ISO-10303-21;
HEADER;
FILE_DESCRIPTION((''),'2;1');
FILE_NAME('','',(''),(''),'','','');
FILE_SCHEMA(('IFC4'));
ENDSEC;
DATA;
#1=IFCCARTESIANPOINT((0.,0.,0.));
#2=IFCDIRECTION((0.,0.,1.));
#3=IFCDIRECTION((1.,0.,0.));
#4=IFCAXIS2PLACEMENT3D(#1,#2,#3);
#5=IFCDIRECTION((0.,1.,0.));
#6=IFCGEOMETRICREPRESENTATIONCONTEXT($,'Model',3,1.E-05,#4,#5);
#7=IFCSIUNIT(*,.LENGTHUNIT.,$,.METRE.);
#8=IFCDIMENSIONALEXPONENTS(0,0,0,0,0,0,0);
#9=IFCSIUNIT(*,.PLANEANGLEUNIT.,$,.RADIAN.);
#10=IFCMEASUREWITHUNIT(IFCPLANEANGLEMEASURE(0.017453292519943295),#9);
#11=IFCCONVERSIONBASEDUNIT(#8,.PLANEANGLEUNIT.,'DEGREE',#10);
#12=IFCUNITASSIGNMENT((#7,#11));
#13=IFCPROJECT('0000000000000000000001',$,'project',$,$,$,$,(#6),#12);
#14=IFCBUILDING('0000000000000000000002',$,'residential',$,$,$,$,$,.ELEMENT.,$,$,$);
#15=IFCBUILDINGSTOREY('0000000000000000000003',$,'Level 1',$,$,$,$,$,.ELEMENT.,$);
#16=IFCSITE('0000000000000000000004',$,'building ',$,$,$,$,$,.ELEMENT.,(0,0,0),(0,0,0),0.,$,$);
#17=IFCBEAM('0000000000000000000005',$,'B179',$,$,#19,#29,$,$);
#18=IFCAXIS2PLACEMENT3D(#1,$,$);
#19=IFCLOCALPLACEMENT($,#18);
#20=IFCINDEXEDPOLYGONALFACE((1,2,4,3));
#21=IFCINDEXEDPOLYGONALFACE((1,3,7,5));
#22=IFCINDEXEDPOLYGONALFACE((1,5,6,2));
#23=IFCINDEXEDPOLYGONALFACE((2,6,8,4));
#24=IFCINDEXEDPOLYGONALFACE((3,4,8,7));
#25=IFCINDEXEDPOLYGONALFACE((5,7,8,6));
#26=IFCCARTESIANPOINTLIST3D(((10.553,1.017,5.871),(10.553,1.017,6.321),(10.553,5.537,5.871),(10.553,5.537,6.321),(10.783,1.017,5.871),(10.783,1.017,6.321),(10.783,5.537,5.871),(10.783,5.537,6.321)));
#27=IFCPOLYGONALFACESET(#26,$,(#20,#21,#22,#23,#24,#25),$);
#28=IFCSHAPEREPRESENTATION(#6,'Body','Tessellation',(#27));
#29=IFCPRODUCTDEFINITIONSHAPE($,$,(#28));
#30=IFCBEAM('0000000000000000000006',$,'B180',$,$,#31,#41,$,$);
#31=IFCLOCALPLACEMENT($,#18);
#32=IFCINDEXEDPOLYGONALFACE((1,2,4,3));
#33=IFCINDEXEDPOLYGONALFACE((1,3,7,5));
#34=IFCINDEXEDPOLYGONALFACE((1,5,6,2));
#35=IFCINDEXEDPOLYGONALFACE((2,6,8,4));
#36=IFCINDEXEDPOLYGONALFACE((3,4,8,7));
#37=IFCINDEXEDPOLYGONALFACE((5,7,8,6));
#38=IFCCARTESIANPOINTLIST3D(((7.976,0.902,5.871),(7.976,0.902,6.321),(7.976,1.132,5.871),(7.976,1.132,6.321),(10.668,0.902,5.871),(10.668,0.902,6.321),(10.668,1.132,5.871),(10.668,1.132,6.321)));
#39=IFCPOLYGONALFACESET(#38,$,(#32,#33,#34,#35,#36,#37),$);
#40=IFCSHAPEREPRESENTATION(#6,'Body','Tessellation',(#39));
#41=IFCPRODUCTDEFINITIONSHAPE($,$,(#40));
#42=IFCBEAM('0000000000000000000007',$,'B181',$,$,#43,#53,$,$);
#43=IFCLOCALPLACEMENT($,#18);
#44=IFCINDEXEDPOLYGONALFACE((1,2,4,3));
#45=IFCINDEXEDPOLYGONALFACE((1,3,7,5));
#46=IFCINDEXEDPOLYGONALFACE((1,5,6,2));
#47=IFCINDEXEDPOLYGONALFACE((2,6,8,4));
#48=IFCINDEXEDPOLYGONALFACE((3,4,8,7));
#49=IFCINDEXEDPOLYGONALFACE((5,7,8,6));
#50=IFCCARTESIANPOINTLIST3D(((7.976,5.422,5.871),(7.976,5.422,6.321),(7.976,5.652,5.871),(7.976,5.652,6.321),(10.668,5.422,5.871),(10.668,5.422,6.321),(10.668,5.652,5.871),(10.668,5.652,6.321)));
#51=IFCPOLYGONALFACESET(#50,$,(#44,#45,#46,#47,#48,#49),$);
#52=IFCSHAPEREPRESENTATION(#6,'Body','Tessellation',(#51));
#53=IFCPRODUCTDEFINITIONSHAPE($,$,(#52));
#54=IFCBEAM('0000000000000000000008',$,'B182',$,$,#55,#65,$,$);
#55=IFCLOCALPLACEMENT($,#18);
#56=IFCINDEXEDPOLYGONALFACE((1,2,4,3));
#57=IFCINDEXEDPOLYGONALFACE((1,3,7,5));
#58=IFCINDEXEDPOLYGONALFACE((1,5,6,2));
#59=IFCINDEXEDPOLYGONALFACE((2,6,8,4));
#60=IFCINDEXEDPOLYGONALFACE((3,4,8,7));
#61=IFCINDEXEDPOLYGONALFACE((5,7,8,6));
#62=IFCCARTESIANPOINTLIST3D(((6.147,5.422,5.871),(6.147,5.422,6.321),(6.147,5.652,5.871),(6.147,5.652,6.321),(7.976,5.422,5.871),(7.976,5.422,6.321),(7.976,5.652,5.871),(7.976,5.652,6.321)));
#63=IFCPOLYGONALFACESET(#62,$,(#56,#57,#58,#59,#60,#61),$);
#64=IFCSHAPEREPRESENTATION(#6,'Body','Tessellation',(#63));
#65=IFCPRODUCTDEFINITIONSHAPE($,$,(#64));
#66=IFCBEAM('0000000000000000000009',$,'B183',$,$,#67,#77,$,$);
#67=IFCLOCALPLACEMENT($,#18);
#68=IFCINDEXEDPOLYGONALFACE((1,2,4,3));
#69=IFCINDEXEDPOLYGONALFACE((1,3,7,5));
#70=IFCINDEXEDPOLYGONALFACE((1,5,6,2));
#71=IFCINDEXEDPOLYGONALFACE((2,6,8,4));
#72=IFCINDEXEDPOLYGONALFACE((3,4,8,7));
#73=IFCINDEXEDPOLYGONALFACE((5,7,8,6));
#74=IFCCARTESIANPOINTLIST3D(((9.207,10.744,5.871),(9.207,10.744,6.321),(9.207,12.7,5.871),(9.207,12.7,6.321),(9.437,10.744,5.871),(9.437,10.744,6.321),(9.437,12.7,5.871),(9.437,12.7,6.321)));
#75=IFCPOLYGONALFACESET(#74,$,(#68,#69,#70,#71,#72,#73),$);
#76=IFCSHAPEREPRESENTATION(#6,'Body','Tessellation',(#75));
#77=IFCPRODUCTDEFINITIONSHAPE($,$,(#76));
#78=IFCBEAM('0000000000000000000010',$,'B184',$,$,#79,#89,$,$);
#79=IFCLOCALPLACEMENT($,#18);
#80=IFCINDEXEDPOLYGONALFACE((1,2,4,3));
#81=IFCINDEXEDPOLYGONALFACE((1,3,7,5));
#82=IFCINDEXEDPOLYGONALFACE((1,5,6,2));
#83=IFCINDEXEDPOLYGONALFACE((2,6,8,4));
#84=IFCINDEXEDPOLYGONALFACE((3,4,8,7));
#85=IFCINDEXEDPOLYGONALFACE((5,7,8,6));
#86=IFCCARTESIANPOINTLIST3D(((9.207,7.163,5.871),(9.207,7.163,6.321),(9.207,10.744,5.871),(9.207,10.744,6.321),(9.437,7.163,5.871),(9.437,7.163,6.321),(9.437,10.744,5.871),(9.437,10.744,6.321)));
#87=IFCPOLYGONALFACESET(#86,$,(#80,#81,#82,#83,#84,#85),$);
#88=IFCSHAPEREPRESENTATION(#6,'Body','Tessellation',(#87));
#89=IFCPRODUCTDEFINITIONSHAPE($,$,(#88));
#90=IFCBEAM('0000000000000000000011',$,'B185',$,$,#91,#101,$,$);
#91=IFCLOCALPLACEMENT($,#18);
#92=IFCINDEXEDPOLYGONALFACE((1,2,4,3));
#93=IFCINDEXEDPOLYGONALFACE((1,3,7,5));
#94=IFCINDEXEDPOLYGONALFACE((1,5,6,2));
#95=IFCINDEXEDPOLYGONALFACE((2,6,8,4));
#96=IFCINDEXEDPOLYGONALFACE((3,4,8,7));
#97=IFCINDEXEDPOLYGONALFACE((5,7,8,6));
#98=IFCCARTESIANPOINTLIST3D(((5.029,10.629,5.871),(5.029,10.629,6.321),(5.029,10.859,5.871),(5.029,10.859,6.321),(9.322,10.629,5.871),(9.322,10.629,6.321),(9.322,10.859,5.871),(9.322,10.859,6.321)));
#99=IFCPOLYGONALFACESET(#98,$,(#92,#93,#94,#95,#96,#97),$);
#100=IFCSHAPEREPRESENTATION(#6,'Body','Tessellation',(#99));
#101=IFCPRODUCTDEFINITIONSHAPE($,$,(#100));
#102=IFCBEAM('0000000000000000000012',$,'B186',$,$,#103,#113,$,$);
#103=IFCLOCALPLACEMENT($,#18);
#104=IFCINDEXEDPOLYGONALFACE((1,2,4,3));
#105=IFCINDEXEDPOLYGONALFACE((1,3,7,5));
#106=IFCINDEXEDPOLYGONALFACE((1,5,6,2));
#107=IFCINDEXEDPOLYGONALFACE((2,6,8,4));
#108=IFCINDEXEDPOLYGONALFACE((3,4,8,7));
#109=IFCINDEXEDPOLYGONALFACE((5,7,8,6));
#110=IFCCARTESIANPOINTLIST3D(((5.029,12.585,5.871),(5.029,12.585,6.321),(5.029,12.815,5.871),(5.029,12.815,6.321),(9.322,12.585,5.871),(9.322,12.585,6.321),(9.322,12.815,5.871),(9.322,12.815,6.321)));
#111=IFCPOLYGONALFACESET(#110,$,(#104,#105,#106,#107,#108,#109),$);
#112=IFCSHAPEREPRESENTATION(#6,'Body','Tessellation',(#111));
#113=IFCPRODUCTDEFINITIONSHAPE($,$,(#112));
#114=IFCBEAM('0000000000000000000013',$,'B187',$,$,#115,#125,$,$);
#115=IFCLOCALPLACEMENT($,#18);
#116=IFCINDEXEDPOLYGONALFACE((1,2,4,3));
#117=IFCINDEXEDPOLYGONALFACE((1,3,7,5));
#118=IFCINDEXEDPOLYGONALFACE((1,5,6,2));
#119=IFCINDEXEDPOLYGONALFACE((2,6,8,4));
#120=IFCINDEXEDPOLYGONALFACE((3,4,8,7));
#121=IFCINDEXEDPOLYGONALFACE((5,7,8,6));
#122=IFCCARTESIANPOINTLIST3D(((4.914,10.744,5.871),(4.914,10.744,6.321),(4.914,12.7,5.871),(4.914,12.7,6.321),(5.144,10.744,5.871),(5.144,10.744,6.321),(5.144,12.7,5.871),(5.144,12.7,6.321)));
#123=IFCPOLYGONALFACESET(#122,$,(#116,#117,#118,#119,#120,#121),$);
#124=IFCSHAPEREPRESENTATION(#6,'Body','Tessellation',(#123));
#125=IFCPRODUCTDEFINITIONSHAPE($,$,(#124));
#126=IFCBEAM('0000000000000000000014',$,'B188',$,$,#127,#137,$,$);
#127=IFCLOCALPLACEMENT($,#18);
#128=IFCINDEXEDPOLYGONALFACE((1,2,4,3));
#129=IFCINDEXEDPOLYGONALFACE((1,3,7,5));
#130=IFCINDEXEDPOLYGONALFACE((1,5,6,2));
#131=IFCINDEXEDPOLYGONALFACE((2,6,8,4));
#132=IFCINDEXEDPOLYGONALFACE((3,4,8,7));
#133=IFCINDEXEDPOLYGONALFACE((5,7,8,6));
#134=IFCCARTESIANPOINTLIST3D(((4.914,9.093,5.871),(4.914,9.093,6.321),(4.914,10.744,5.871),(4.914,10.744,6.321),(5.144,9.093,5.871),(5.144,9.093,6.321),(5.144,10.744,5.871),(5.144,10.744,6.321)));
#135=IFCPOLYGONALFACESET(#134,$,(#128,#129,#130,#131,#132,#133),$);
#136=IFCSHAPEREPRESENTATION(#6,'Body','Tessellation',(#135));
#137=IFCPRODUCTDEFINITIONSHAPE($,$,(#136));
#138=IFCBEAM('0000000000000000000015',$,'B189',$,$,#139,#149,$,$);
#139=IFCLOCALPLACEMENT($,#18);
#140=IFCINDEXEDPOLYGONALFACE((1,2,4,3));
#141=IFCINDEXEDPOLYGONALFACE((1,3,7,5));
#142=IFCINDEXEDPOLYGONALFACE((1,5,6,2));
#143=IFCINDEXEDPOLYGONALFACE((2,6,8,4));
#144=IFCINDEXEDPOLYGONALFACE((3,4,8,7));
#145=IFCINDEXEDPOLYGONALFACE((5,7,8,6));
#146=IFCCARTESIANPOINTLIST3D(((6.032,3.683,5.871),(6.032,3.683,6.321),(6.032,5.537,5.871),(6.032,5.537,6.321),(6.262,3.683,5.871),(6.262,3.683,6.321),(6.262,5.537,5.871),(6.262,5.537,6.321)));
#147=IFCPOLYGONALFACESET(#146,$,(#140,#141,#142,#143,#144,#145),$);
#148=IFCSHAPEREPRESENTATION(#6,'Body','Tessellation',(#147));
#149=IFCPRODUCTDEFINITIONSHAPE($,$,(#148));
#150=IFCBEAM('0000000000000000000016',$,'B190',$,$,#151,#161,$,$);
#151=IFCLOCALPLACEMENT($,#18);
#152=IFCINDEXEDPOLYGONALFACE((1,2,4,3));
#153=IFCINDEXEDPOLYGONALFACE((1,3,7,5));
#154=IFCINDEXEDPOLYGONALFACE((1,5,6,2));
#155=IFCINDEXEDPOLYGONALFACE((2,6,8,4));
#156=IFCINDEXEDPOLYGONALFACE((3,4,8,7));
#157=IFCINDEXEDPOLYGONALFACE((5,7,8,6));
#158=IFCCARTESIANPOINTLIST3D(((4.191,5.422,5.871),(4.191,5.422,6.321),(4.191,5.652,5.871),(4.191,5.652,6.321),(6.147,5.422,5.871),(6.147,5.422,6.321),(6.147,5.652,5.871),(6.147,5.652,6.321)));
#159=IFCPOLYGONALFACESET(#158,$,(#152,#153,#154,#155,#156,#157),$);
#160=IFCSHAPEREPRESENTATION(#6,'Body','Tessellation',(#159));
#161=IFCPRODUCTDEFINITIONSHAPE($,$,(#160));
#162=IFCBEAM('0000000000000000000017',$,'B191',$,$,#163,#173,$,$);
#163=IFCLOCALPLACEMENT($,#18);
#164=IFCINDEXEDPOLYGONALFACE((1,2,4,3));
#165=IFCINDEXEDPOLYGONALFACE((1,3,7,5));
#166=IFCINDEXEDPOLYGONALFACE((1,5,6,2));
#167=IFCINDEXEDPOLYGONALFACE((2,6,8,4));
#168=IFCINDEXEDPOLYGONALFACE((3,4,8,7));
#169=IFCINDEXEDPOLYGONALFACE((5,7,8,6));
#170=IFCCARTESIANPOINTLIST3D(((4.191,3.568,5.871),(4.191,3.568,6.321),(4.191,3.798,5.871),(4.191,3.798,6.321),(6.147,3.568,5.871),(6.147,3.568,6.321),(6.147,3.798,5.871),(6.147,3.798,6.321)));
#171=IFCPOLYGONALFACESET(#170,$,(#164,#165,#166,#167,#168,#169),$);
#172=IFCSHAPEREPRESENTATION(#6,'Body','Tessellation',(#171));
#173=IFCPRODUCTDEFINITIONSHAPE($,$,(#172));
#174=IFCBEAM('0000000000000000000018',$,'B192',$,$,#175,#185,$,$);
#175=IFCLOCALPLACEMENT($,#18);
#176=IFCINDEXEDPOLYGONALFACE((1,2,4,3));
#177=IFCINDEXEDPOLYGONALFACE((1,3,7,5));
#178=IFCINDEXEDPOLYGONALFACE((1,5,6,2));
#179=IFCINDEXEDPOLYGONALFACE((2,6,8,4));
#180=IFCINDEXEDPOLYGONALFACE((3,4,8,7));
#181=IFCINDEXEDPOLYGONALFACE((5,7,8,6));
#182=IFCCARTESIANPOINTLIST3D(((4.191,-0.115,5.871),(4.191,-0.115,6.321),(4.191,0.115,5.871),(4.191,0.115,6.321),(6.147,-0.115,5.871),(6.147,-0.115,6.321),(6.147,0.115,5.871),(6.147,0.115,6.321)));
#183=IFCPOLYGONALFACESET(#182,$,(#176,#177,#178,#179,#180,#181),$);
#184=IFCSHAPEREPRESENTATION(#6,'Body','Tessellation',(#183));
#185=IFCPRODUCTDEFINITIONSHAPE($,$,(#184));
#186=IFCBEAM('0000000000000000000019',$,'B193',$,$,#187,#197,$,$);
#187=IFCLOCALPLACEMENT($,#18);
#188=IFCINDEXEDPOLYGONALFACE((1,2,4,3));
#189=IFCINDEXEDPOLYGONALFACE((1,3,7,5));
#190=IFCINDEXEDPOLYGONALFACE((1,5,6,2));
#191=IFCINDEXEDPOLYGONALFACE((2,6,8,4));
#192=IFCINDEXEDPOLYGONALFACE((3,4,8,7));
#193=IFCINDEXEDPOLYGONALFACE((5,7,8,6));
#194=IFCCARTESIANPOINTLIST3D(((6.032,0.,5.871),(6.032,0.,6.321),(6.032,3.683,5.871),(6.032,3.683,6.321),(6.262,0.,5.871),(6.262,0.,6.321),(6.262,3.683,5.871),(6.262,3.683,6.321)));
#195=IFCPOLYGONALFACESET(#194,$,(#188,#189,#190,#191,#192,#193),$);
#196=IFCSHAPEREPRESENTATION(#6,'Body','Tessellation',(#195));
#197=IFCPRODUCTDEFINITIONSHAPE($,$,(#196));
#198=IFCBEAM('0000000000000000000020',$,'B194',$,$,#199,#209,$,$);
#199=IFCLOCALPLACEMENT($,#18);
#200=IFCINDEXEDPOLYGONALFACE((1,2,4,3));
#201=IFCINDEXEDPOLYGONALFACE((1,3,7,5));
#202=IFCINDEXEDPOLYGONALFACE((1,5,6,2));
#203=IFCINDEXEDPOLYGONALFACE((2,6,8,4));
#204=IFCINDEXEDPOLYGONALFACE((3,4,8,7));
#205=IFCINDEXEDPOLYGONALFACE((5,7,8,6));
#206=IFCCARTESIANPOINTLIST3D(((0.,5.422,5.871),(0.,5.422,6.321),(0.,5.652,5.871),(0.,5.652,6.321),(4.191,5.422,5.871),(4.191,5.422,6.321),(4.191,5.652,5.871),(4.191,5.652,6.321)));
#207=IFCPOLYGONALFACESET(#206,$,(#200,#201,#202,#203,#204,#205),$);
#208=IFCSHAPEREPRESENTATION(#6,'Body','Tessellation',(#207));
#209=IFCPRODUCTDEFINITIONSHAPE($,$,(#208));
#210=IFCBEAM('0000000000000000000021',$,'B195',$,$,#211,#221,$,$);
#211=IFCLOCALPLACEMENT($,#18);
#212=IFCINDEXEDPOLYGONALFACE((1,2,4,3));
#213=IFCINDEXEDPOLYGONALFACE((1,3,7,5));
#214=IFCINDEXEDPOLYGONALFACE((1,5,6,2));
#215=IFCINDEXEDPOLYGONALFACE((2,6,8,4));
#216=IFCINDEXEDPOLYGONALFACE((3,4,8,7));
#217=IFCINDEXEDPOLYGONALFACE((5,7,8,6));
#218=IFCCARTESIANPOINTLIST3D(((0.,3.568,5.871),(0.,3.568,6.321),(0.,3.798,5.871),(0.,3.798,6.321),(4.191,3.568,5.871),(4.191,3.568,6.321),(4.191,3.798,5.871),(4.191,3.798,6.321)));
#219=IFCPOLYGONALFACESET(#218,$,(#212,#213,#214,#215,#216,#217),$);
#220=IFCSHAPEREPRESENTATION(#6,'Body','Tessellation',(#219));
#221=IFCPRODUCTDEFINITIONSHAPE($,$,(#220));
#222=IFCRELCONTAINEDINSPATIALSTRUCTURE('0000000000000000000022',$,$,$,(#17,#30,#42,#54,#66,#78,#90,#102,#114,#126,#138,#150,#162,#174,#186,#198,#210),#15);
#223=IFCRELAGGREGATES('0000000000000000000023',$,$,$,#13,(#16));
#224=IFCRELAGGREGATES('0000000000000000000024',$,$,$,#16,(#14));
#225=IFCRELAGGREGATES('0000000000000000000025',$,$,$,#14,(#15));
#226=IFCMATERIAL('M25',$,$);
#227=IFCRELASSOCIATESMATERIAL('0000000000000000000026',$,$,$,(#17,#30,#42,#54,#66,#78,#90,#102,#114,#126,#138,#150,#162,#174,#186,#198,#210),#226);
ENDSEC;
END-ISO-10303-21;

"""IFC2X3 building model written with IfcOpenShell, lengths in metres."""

from ifc_helpers import new_model, entity, si_unit, converted_unit, direction, frame, frame_2d, origin_with_axes, place, context, project, spatial, rectangle, extrude, material, element, save


model = new_model("IFC2X3")

# Units and contexts
model_context = context("Model", 3, precision=1e-05, world=origin_with_axes(), true_north=direction((0.0, 1.0, 0.0)))
ifc_project = project(units=[si_unit("LENGTHUNIT", "METRE"), converted_unit("PLANEANGLEUNIT", "DEGREE", entity("IfcPlaneAngleMeasure", 0.017453292519943295), si_unit("PLANEANGLEUNIT", "RADIAN"), dimensions=[0, 0, 0, 0, 0, 0, 0])], contexts=[model_context])

# Site, building, storey
site = spatial("IfcSite", under=ifc_project, Name="building ", CompositionType="ELEMENT", RefLatitude=(0, 0, 0), RefLongitude=(0, 0, 0), RefElevation=0.0)
building = spatial("IfcBuilding", under=site, Name="residential", CompositionType="ELEMENT")
storey = spatial("IfcBuildingStorey", under=building, Name="Level 1", CompositionType="ELEMENT")

# Beams
ifc_material = material(Name="M25")
placement = place(None, origin_with_axes())
element("IfcBeam", 1, at=placement, inside=storey, material=ifc_material, Name="B179", context=model_context, shape_type="SweptSolid", body=[
    extrude(rectangle(XDim=0.23, YDim=0.45, at=frame_2d((0.0, 0.0), x_axis=(0.0, 1.0, 0.0))), frame((10.668, 1.017, 6.096), z_axis=(0.0, 1.0, 0.0), x_axis=(0.0, 0.0, -1.0)), (0.0, 0.0, 1.0), 4.52),
])
element("IfcBeam", 2, at=placement, inside=storey, material=ifc_material, Name="B180", context=model_context, shape_type="SweptSolid", body=[
    extrude(rectangle(XDim=0.23, YDim=0.45, at=frame_2d((0.0, 0.0), x_axis=(0.0, 1.0, 0.0))), frame((7.976, 1.017, 6.096), z_axis=(1.0, 0.0, 0.0), x_axis=(0.0, 0.0, -1.0)), (0.0, 0.0, 1.0), 2.692),
])
element("IfcBeam", 3, at=placement, inside=storey, material=ifc_material, Name="B181", context=model_context, shape_type="SweptSolid", body=[
    extrude(rectangle(XDim=0.23, YDim=0.45, at=frame_2d((0.0, 0.0), x_axis=(0.0, 1.0, 0.0))), frame((7.976, 5.537, 6.096), z_axis=(1.0, 0.0, 0.0), x_axis=(0.0, 0.0, -1.0)), (0.0, 0.0, 1.0), 2.692),
])
element("IfcBeam", 4, at=placement, inside=storey, material=ifc_material, Name="B182", context=model_context, shape_type="SweptSolid", body=[
    extrude(rectangle(XDim=0.23, YDim=0.45, at=frame_2d((0.0, 0.0), x_axis=(0.0, 1.0, 0.0))), frame((6.147, 5.537, 6.096), z_axis=(1.0, 0.0, 0.0), x_axis=(0.0, 0.0, -1.0)), (0.0, 0.0, 1.0), 1.829),
])
element("IfcBeam", 5, at=placement, inside=storey, material=ifc_material, Name="B183", context=model_context, shape_type="SweptSolid", body=[
    extrude(rectangle(XDim=0.23, YDim=0.45, at=frame_2d((0.0, 0.0), x_axis=(0.0, 1.0, 0.0))), frame((9.322, 10.744, 6.096), z_axis=(0.0, 1.0, 0.0), x_axis=(0.0, 0.0, -1.0)), (0.0, 0.0, 1.0), 1.956),
])
element("IfcBeam", 6, at=placement, inside=storey, material=ifc_material, Name="B184", context=model_context, shape_type="SweptSolid", body=[
    extrude(rectangle(XDim=0.23, YDim=0.45, at=frame_2d((0.0, 0.0), x_axis=(0.0, 1.0, 0.0))), frame((9.322, 7.163, 6.096), z_axis=(0.0, 1.0, 0.0), x_axis=(0.0, 0.0, -1.0)), (0.0, 0.0, 1.0), 3.581),
])
element("IfcBeam", 7, at=placement, inside=storey, material=ifc_material, Name="B185", context=model_context, shape_type="SweptSolid", body=[
    extrude(rectangle(XDim=0.23, YDim=0.45, at=frame_2d((0.0, 0.0), x_axis=(0.0, 1.0, 0.0))), frame((5.029, 10.744, 6.096), z_axis=(1.0, 0.0, 0.0), x_axis=(0.0, 0.0, -1.0)), (0.0, 0.0, 1.0), 4.293),
])
element("IfcBeam", 8, at=placement, inside=storey, material=ifc_material, Name="B186", context=model_context, shape_type="SweptSolid", body=[
    extrude(rectangle(XDim=0.23, YDim=0.45, at=frame_2d((0.0, 0.0), x_axis=(0.0, 1.0, 0.0))), frame((5.029, 12.7, 6.096), z_axis=(1.0, 0.0, 0.0), x_axis=(0.0, 0.0, -1.0)), (0.0, 0.0, 1.0), 4.293),
])
element("IfcBeam", 9, at=placement, inside=storey, material=ifc_material, Name="B187", context=model_context, shape_type="SweptSolid", body=[
    extrude(rectangle(XDim=0.23, YDim=0.45, at=frame_2d((0.0, 0.0), x_axis=(0.0, 1.0, 0.0))), frame((5.029, 10.744, 6.096), z_axis=(0.0, 1.0, 0.0), x_axis=(0.0, 0.0, -1.0)), (0.0, 0.0, 1.0), 1.956),
])
element("IfcBeam", 10, at=placement, inside=storey, material=ifc_material, Name="B188", context=model_context, shape_type="SweptSolid", body=[
    extrude(rectangle(XDim=0.23, YDim=0.45, at=frame_2d((0.0, 0.0), x_axis=(0.0, 1.0, 0.0))), frame((5.029, 9.093, 6.096), z_axis=(0.0, 1.0, 0.0), x_axis=(0.0, 0.0, -1.0)), (0.0, 0.0, 1.0), 1.651),
])
element("IfcBeam", 11, at=placement, inside=storey, material=ifc_material, Name="B189", context=model_context, shape_type="SweptSolid", body=[
    extrude(rectangle(XDim=0.23, YDim=0.45, at=frame_2d((0.0, 0.0), x_axis=(0.0, 1.0, 0.0))), frame((6.147, 3.683, 6.096), z_axis=(0.0, 1.0, 0.0), x_axis=(0.0, 0.0, -1.0)), (0.0, 0.0, 1.0), 1.854),
])
element("IfcBeam", 12, at=placement, inside=storey, material=ifc_material, Name="B190", context=model_context, shape_type="SweptSolid", body=[
    extrude(rectangle(XDim=0.23, YDim=0.45, at=frame_2d((0.0, 0.0), x_axis=(0.0, 1.0, 0.0))), frame((4.191, 5.537, 6.096), z_axis=(1.0, 0.0, 0.0), x_axis=(0.0, 0.0, -1.0)), (0.0, 0.0, 1.0), 1.956),
])
element("IfcBeam", 13, at=placement, inside=storey, material=ifc_material, Name="B191", context=model_context, shape_type="SweptSolid", body=[
    extrude(rectangle(XDim=0.23, YDim=0.45, at=frame_2d((0.0, 0.0), x_axis=(0.0, 1.0, 0.0))), frame((4.191, 3.683, 6.096), z_axis=(1.0, 0.0, 0.0), x_axis=(0.0, 0.0, -1.0)), (0.0, 0.0, 1.0), 1.956),
])
element("IfcBeam", 14, at=placement, inside=storey, material=ifc_material, Name="B192", context=model_context, shape_type="SweptSolid", body=[
    extrude(rectangle(XDim=0.23, YDim=0.45, at=frame_2d((0.0, 0.0), x_axis=(0.0, 1.0, 0.0))), frame((4.191, 0.0, 6.096), z_axis=(1.0, 0.0, 0.0), x_axis=(0.0, 0.0, -1.0)), (0.0, 0.0, 1.0), 1.956),
])
element("IfcBeam", 15, at=placement, inside=storey, material=ifc_material, Name="B193", context=model_context, shape_type="SweptSolid", body=[
    extrude(rectangle(XDim=0.23, YDim=0.45, at=frame_2d((0.0, 0.0), x_axis=(0.0, 1.0, 0.0))), frame((6.147, 0.0, 6.096), z_axis=(0.0, 1.0, 0.0), x_axis=(0.0, 0.0, -1.0)), (0.0, 0.0, 1.0), 3.683),
])
element("IfcBeam", 16, at=placement, inside=storey, material=ifc_material, Name="B194", context=model_context, shape_type="SweptSolid", body=[
    extrude(rectangle(XDim=0.23, YDim=0.45, at=frame_2d((0.0, 0.0), x_axis=(0.0, 1.0, 0.0))), frame((0.0, 5.537, 6.096), z_axis=(1.0, 0.0, 0.0), x_axis=(0.0, 0.0, -1.0)), (0.0, 0.0, 1.0), 4.191),
])
element("IfcBeam", 17, at=placement, inside=storey, material=ifc_material, Name="B195", context=model_context, shape_type="SweptSolid", body=[
    extrude(rectangle(XDim=0.23, YDim=0.45, at=frame_2d((0.0, 0.0), x_axis=(0.0, 1.0, 0.0))), frame((0.0, 3.683, 6.096), z_axis=(1.0, 0.0, 0.0), x_axis=(0.0, 0.0, -1.0)), (0.0, 0.0, 1.0), 4.191),
])

save(model, "model.ifc")
